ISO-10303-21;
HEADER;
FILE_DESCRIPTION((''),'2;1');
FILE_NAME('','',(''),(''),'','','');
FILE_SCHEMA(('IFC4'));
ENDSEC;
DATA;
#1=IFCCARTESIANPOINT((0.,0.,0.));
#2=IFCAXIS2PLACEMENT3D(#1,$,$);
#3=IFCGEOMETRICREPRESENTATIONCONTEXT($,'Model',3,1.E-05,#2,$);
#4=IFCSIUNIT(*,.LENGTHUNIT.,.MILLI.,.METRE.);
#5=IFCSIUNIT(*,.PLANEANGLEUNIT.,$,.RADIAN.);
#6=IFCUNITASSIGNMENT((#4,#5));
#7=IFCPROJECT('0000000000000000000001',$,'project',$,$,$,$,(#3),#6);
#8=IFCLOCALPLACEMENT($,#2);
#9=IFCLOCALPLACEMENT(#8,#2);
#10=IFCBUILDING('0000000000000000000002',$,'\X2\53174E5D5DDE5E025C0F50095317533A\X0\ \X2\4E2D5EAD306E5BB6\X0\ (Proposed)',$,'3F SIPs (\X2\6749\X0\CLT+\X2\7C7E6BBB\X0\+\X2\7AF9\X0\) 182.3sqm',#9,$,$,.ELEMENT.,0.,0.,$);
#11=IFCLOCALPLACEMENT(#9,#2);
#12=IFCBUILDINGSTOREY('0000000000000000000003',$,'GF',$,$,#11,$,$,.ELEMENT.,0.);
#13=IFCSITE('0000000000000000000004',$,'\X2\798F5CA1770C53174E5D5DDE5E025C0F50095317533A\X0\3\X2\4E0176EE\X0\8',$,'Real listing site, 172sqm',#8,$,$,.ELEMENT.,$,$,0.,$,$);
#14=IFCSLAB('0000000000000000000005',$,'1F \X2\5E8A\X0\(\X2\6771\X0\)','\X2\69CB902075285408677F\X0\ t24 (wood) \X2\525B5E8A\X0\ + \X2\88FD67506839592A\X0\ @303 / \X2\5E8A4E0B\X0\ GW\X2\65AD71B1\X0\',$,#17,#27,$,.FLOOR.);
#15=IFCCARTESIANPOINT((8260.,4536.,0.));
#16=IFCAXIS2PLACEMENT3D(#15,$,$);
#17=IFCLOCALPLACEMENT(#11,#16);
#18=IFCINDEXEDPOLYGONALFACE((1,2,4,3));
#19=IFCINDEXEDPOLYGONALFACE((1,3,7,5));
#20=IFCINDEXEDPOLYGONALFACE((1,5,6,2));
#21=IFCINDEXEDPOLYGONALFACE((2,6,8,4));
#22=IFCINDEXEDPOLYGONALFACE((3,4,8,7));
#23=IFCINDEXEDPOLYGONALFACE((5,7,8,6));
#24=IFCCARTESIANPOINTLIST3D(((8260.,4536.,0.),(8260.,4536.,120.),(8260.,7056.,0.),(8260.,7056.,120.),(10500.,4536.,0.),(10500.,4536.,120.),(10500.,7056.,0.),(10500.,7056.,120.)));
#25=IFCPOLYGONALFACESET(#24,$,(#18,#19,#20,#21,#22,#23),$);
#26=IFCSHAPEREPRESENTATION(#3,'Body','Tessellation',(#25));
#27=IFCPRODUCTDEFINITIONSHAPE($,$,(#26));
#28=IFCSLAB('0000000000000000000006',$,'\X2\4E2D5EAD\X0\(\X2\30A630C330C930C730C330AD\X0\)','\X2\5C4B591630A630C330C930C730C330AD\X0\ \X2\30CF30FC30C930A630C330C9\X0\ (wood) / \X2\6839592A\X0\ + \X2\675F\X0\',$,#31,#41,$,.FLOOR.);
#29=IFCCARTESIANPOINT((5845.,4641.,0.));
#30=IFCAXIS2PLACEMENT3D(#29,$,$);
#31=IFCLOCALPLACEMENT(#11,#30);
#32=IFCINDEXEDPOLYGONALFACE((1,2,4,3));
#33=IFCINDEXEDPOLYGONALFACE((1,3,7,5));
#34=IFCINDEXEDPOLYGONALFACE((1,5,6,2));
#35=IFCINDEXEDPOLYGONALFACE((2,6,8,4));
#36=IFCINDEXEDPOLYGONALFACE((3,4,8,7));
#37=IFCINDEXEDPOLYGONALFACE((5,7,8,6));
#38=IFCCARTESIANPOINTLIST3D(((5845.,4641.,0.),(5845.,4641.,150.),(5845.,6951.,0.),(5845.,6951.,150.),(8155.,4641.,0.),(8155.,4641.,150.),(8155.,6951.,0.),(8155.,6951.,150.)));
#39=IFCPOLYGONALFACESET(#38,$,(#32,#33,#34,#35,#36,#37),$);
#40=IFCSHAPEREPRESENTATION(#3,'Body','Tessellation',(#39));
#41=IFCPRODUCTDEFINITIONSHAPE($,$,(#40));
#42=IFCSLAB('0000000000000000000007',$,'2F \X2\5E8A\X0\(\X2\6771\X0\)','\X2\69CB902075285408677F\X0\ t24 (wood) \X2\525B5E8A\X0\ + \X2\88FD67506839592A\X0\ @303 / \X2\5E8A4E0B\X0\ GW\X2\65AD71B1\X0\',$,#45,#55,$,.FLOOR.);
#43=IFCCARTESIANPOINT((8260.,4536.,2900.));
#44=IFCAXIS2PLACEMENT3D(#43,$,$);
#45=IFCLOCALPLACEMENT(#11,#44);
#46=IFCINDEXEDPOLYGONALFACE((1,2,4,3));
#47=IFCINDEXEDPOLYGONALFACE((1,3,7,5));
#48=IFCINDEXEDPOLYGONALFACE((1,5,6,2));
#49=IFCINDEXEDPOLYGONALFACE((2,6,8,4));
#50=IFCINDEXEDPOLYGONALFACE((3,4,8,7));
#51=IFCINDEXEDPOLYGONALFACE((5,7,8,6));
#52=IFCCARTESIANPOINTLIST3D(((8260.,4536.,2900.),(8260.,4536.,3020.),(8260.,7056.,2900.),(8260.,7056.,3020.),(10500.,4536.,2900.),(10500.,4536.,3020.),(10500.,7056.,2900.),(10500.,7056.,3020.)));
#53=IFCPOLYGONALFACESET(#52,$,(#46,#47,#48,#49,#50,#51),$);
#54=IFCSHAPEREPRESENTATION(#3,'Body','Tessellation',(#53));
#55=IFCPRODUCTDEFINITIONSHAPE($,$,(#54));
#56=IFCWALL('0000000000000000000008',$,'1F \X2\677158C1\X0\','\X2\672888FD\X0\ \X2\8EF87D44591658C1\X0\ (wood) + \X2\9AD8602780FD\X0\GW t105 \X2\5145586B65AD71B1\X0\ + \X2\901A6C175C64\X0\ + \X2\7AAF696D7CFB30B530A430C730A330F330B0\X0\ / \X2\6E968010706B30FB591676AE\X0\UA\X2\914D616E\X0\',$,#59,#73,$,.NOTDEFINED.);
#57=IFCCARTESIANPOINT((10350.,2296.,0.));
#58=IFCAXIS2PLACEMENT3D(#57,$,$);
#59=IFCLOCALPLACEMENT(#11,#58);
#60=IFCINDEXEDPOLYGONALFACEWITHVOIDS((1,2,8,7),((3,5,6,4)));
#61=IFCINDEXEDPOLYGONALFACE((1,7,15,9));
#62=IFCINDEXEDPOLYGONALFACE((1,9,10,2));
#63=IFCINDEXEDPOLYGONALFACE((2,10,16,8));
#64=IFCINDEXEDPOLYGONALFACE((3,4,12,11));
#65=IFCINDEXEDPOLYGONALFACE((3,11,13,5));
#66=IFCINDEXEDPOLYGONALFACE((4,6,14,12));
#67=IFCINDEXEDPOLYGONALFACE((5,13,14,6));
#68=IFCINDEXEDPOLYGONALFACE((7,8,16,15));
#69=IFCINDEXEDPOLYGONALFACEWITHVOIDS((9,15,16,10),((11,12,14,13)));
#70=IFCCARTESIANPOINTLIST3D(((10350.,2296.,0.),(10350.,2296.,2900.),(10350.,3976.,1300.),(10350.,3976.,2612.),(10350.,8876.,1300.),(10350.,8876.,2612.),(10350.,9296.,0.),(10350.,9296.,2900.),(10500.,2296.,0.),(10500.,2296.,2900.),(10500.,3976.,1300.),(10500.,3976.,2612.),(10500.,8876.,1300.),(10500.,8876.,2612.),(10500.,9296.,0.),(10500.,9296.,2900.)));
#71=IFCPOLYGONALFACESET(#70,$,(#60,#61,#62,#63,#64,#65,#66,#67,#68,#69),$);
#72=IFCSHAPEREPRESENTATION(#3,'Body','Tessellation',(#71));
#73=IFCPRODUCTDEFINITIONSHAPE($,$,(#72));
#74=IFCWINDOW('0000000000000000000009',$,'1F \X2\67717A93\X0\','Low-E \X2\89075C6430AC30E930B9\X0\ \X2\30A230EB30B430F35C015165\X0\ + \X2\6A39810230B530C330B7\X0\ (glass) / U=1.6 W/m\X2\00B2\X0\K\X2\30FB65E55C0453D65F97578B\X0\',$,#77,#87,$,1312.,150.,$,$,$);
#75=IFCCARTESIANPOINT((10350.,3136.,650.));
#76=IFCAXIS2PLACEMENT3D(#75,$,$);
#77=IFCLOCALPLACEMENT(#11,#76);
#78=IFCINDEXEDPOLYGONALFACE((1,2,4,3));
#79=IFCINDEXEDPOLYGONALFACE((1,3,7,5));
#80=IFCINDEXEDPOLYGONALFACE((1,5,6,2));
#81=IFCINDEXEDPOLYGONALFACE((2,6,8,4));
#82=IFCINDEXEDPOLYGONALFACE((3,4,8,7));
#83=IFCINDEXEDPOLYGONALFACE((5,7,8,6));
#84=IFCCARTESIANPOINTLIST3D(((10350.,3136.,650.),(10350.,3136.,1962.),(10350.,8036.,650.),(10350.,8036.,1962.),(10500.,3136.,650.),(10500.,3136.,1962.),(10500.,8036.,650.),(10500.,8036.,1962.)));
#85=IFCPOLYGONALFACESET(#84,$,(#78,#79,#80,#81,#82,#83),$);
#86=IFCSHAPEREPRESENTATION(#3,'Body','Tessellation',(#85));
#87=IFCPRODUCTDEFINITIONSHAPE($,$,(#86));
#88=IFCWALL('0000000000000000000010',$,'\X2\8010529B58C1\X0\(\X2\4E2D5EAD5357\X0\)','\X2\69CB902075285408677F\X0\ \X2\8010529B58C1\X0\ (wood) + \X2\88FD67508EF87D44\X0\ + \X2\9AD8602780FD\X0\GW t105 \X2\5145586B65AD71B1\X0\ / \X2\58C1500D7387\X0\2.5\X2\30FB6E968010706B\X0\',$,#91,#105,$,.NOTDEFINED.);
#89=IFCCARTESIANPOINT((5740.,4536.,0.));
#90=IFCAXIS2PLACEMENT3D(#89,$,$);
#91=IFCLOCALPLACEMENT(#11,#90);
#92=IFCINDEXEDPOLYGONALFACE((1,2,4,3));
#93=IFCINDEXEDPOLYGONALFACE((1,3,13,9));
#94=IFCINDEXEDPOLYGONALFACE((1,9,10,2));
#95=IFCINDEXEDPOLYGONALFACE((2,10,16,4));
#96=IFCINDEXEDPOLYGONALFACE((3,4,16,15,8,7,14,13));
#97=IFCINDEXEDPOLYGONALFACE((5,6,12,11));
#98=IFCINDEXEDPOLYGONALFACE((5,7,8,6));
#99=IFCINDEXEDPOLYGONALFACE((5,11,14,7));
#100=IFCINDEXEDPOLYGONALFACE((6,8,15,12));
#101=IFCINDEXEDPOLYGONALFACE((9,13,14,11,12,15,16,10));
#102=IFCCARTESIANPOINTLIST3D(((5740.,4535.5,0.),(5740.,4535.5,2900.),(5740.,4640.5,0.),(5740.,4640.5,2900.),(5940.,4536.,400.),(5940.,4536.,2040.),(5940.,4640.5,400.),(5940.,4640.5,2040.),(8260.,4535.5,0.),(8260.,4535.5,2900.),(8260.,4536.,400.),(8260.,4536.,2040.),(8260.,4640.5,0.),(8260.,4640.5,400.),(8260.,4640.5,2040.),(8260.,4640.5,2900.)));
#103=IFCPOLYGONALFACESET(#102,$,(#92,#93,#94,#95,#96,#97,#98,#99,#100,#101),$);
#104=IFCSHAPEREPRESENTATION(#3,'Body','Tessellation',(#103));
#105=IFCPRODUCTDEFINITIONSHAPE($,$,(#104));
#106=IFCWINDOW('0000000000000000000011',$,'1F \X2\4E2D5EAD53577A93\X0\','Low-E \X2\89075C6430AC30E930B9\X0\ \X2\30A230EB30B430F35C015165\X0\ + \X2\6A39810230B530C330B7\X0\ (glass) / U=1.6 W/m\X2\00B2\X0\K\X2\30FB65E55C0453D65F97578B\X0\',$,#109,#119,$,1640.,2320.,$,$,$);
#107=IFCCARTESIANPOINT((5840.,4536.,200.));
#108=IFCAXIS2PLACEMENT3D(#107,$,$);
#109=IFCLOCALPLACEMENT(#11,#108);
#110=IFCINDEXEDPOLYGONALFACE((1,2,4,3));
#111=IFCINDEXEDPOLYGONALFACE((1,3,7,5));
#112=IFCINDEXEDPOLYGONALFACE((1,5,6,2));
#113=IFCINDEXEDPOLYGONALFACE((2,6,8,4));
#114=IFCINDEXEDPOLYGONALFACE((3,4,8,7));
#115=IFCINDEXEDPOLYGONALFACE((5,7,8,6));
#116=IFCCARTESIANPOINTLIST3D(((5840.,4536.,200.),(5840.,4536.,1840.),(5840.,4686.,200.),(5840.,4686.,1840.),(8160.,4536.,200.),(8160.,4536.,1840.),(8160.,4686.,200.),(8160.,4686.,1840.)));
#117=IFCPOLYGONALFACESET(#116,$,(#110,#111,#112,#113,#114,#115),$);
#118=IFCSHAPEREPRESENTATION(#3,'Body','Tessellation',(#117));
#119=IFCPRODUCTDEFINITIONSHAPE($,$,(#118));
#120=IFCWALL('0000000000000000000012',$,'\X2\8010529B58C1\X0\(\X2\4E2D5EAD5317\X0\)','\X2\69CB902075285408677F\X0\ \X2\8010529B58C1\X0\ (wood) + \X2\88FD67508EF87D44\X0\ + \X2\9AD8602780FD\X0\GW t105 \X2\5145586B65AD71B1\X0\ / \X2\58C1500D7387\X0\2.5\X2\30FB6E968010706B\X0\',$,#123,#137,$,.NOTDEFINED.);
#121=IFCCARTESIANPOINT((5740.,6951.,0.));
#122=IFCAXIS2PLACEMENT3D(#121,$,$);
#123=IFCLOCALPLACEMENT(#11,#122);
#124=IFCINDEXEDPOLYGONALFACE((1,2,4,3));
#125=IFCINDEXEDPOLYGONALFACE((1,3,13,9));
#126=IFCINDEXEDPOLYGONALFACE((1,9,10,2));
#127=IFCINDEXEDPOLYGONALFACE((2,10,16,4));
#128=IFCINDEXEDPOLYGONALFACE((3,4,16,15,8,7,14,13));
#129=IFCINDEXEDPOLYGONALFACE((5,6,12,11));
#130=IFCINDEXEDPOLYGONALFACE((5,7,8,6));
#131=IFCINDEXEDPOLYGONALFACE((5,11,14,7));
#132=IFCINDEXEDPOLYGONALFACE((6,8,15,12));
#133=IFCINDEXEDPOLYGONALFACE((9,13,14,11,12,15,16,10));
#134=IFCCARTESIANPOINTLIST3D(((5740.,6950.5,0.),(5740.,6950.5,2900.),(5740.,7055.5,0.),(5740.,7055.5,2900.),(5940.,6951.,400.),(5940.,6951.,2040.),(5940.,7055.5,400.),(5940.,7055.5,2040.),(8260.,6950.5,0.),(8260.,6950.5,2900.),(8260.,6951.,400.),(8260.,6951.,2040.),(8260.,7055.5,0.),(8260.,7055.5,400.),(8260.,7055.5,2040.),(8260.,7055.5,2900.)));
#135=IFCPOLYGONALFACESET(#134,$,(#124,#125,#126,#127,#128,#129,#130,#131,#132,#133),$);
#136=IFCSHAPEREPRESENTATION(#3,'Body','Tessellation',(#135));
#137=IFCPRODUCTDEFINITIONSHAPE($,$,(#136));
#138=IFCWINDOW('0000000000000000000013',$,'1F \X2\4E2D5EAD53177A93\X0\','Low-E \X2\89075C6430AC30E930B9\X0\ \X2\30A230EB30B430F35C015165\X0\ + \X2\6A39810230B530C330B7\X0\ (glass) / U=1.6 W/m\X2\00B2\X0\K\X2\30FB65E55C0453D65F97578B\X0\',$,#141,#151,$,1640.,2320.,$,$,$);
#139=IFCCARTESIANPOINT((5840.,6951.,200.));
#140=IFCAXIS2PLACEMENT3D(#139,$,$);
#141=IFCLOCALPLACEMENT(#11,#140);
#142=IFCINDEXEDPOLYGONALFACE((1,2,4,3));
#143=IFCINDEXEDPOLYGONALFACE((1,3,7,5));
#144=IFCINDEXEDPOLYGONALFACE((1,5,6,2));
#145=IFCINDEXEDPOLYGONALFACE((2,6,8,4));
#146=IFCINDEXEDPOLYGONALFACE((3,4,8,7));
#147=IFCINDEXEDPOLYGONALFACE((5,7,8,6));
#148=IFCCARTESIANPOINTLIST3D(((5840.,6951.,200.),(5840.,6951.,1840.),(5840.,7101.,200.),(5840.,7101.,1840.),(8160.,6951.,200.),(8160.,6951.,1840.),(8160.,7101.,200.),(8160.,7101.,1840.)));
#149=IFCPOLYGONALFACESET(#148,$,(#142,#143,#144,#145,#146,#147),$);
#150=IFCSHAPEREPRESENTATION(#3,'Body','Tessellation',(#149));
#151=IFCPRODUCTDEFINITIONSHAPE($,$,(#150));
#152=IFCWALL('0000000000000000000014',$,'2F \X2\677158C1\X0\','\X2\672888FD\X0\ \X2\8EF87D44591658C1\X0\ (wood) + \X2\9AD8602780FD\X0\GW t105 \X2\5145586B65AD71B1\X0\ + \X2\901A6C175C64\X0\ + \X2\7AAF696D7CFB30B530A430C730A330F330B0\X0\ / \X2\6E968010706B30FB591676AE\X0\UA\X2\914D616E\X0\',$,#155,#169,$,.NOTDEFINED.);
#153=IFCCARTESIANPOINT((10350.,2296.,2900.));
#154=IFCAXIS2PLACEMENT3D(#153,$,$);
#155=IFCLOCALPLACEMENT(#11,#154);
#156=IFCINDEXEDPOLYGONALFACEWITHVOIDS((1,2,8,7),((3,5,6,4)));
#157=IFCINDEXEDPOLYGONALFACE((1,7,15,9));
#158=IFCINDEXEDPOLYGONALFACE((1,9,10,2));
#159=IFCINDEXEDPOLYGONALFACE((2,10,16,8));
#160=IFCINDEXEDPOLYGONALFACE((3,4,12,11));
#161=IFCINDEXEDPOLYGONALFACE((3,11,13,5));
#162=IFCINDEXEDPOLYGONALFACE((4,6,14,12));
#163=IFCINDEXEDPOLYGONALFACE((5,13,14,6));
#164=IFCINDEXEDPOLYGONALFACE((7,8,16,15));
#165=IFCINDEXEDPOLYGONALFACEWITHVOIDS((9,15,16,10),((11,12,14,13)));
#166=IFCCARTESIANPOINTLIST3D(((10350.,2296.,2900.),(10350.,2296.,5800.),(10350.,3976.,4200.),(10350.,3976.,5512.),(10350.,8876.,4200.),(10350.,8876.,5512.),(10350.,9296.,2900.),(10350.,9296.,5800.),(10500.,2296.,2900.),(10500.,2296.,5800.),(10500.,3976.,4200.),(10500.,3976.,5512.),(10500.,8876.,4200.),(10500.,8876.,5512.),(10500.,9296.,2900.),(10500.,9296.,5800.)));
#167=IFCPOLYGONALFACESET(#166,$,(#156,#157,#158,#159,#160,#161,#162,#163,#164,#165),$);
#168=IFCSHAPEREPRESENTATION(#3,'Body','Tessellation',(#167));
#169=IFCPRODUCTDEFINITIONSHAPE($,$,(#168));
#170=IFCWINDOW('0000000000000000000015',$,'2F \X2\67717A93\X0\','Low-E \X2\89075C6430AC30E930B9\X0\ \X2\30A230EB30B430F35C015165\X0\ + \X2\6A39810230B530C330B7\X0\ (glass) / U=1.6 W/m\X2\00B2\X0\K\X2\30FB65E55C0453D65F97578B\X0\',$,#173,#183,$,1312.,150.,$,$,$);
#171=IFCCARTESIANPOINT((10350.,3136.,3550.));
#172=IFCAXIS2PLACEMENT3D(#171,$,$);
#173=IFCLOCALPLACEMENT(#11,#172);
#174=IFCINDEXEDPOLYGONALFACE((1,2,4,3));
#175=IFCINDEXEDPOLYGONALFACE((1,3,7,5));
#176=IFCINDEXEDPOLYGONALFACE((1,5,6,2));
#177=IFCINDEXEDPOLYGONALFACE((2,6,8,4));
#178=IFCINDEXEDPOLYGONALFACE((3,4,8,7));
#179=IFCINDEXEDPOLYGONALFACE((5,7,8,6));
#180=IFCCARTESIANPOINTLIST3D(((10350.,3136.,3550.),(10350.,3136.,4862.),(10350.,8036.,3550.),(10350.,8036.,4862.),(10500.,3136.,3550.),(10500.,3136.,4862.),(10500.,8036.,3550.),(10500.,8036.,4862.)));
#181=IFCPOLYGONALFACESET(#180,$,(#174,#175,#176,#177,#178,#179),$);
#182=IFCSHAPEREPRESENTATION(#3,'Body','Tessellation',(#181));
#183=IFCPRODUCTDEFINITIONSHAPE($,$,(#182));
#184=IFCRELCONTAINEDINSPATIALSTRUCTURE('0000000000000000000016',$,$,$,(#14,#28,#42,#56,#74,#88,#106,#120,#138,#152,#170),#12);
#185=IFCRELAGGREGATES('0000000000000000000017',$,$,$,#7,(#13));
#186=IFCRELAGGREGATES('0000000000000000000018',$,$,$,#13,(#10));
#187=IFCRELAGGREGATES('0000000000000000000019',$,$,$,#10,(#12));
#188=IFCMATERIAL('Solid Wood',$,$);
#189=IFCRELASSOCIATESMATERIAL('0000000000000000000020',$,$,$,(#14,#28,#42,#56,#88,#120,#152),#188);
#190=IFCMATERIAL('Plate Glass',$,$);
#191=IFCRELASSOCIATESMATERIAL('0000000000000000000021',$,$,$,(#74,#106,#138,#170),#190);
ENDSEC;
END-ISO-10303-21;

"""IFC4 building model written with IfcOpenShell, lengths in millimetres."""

from ifc_helpers import new_model, si_unit, frame, frame_2d, origin, place, context, project, spatial, rectangle, extrude, material, element, fill, save


model = new_model("IFC4")

# Units and contexts
model_context = context("Model", 3, precision=1e-05, world=origin())
ifc_project = project(units=[si_unit("LENGTHUNIT", "METRE", prefix="MILLI"), si_unit("PLANEANGLEUNIT", "RADIAN")], contexts=[model_context])

# Site, building, storey
site_placement = place(None, origin())
site = spatial("IfcSite", under=ifc_project, at=site_placement, Name="福岡県北九州市小倉北区3丁目8", ObjectType="Real listing site, 172sqm", CompositionType="ELEMENT", RefElevation=0.0)
building_placement = place(site_placement, origin())
building = spatial("IfcBuilding", under=site, at=building_placement, Name="北九州市小倉北区 中庭の家 (Proposed)", ObjectType="3F SIPs (杉CLT+籾殻+竹) 182.3sqm", CompositionType="ELEMENT", ElevationOfRefHeight=0.0, ElevationOfTerrain=0.0)
storey_placement = place(building_placement, origin())
storey = spatial("IfcBuildingStorey", under=building, at=storey_placement, Name="GF", CompositionType="ELEMENT", Elevation=0.0)

# Slabs
ifc_material_1 = material(Name="Solid Wood")
slab_1_placement = place(storey_placement, frame((8260.0, 4536.0, 0.0)))
element("IfcSlab", 1, at=slab_1_placement, inside=storey, material=ifc_material_1, Name="1F 床(東)", Description="構造用合板 t24 (wood) 剛床 + 製材根太 @303 / 床下 GW断熱", PredefinedType="FLOOR", context=model_context, shape_type="SweptSolid", body=[
    extrude(rectangle(XDim=2240.0, YDim=2520.0, at=frame_2d((1120.0, 1260.0))), frame((8260.0, 4536.0, 0.0)), (0.0, 0.0, 1.0), 120.0),
])
slab_2_placement = place(storey_placement, frame((5845.0, 4641.0, 0.0)))
element("IfcSlab", 2, at=slab_2_placement, inside=storey, material=ifc_material_1, Name="中庭(ウッドデッキ)", Description="屋外ウッドデッキ ハードウッド (wood) / 根太 + 束", PredefinedType="FLOOR", context=model_context, shape_type="SweptSolid", body=[
    extrude(rectangle(XDim=2310.0, YDim=2310.0, at=frame_2d((1155.0, 1155.0))), frame((5845.0, 4641.0, 0.0)), (0.0, 0.0, 1.0), 150.0),
])
slab_3_placement = place(storey_placement, frame((8260.0, 4536.0, 2900.0)))
element("IfcSlab", 3, at=slab_3_placement, inside=storey, material=ifc_material_1, Name="2F 床(東)", Description="構造用合板 t24 (wood) 剛床 + 製材根太 @303 / 床下 GW断熱", PredefinedType="FLOOR", context=model_context, shape_type="SweptSolid", body=[
    extrude(rectangle(XDim=2240.0, YDim=2520.0, at=frame_2d((1120.0, 1260.0))), frame((8260.0, 4536.0, 2900.0)), (0.0, 0.0, 1.0), 120.0),
])

# Walls, openings, windows
wall_1_placement = place(storey_placement, frame((10350.0, 2296.0, 0.0)))
wall_1 = element("IfcWall", 4, at=wall_1_placement, inside=storey, material=ifc_material_1, Name="1F 東壁", Description="木製 軸組外壁 (wood) + 高性能GW t105 充填断熱 + 通気層 + 窯業系サイディング / 準耐火・外皮UA配慮", PredefinedType="NOTDEFINED", context=model_context, shape_type="SweptSolid", body=[
    extrude(rectangle(XDim=150.0, YDim=7000.0, at=frame_2d((75.0, 3500.0))), frame((10350.0, 2296.0, 0.0)), (0.0, 0.0, 1.0), 2900.0),
])
opening_1_placement = place(storey_placement, frame((10350.0, 3136.0, 650.0)))
opening_1 = element("IfcOpeningElement", 5, at=opening_1_placement, cuts=wall_1, PredefinedType="NOTDEFINED", context=model_context, shape_type="SweptSolid", body=[
    extrude(rectangle(XDim=150.0, YDim=4900.0, at=frame_2d((75.0, 2450.0))), frame((10350.0, 3136.0, 650.0)), (0.0, 0.0, 1.0), 1312.0),
])
ifc_material_2 = material(Name="Plate Glass")
window_1_placement = place(storey_placement, frame((10350.0, 3136.0, 650.0)))
window_1 = element("IfcWindow", 6, at=window_1_placement, inside=storey, material=ifc_material_2, Name="1F 東窓", Description="Low-E 複層ガラス アルゴン封入 + 樹脂サッシ (glass) / U=1.6 W/m²K・日射取得型", OverallHeight=1312.0, OverallWidth=150.0, context=model_context, shape_type="SweptSolid", body=[
    extrude(rectangle(XDim=150.0, YDim=4900.0, at=frame_2d((75.0, 2450.0))), frame((10350.0, 3136.0, 650.0)), (0.0, 0.0, 1.0), 1312.0),
])
fill(opening_1, window_1)
wall_2_placement = place(storey_placement, frame((5740.0, 4536.0, 0.0)))
wall_2 = element("IfcWall", 7, at=wall_2_placement, inside=storey, material=ifc_material_1, Name="耐力壁(中庭南)", Description="構造用合板 耐力壁 (wood) + 製材軸組 + 高性能GW t105 充填断熱 / 壁倍率2.5・準耐火", PredefinedType="NOTDEFINED", context=model_context, shape_type="SweptSolid", body=[
    extrude(rectangle(XDim=2520.0, YDim=105.0, at=frame_2d((1260.0, 52.0))), frame((5740.0, 4536.0, 0.0)), (0.0, 0.0, 1.0), 2900.0),
])
opening_2_placement = place(storey_placement, frame((5840.0, 4536.0, 200.0)))
opening_2 = element("IfcOpeningElement", 8, at=opening_2_placement, cuts=wall_2, PredefinedType="NOTDEFINED", context=model_context, shape_type="SweptSolid", body=[
    extrude(rectangle(XDim=2320.0, YDim=150.0, at=frame_2d((1160.0, 75.0))), frame((5840.0, 4536.0, 200.0)), (0.0, 0.0, 1.0), 1640.0),
])
window_2_placement = place(storey_placement, frame((5840.0, 4536.0, 200.0)))
window_2 = element("IfcWindow", 9, at=window_2_placement, inside=storey, material=ifc_material_2, Name="1F 中庭南窓", Description="Low-E 複層ガラス アルゴン封入 + 樹脂サッシ (glass) / U=1.6 W/m²K・日射取得型", OverallHeight=1640.0, OverallWidth=2320.0, context=model_context, shape_type="SweptSolid", body=[
    extrude(rectangle(XDim=2320.0, YDim=150.0, at=frame_2d((1160.0, 75.0))), frame((5840.0, 4536.0, 200.0)), (0.0, 0.0, 1.0), 1640.0),
])
fill(opening_2, window_2)
wall_3_placement = place(storey_placement, frame((5740.0, 6951.0, 0.0)))
wall_3 = element("IfcWall", 10, at=wall_3_placement, inside=storey, material=ifc_material_1, Name="耐力壁(中庭北)", Description="構造用合板 耐力壁 (wood) + 製材軸組 + 高性能GW t105 充填断熱 / 壁倍率2.5・準耐火", PredefinedType="NOTDEFINED", context=model_context, shape_type="SweptSolid", body=[
    extrude(rectangle(XDim=2520.0, YDim=105.0, at=frame_2d((1260.0, 52.0))), frame((5740.0, 6951.0, 0.0)), (0.0, 0.0, 1.0), 2900.0),
])
opening_3_placement = place(storey_placement, frame((5840.0, 6951.0, 200.0)))
opening_3 = element("IfcOpeningElement", 11, at=opening_3_placement, cuts=wall_3, PredefinedType="NOTDEFINED", context=model_context, shape_type="SweptSolid", body=[
    extrude(rectangle(XDim=2320.0, YDim=150.0, at=frame_2d((1160.0, 75.0))), frame((5840.0, 6951.0, 200.0)), (0.0, 0.0, 1.0), 1640.0),
])
window_3_placement = place(storey_placement, frame((5840.0, 6951.0, 200.0)))
window_3 = element("IfcWindow", 12, at=window_3_placement, inside=storey, material=ifc_material_2, Name="1F 中庭北窓", Description="Low-E 複層ガラス アルゴン封入 + 樹脂サッシ (glass) / U=1.6 W/m²K・日射取得型", OverallHeight=1640.0, OverallWidth=2320.0, context=model_context, shape_type="SweptSolid", body=[
    extrude(rectangle(XDim=2320.0, YDim=150.0, at=frame_2d((1160.0, 75.0))), frame((5840.0, 6951.0, 200.0)), (0.0, 0.0, 1.0), 1640.0),
])
fill(opening_3, window_3)

# Wall, opening, window
wall_4_placement = place(storey_placement, frame((10350.0, 2296.0, 2900.0)))
wall_4 = element("IfcWall", 13, at=wall_4_placement, inside=storey, material=ifc_material_1, Name="2F 東壁", Description="木製 軸組外壁 (wood) + 高性能GW t105 充填断熱 + 通気層 + 窯業系サイディング / 準耐火・外皮UA配慮", PredefinedType="NOTDEFINED", context=model_context, shape_type="SweptSolid", body=[
    extrude(rectangle(XDim=150.0, YDim=7000.0, at=frame_2d((75.0, 3500.0))), frame((10350.0, 2296.0, 2900.0)), (0.0, 0.0, 1.0), 2900.0),
])
opening_4_placement = place(storey_placement, frame((10350.0, 3136.0, 3550.0)))
opening_4 = element("IfcOpeningElement", 14, at=opening_4_placement, cuts=wall_4, PredefinedType="NOTDEFINED", context=model_context, shape_type="SweptSolid", body=[
    extrude(rectangle(XDim=150.0, YDim=4900.0, at=frame_2d((75.0, 2450.0))), frame((10350.0, 3136.0, 3550.0)), (0.0, 0.0, 1.0), 1312.0),
])
window_4_placement = place(storey_placement, frame((10350.0, 3136.0, 3550.0)))
window_4 = element("IfcWindow", 15, at=window_4_placement, inside=storey, material=ifc_material_2, Name="2F 東窓", Description="Low-E 複層ガラス アルゴン封入 + 樹脂サッシ (glass) / U=1.6 W/m²K・日射取得型", OverallHeight=1312.0, OverallWidth=150.0, context=model_context, shape_type="SweptSolid", body=[
    extrude(rectangle(XDim=150.0, YDim=4900.0, at=frame_2d((75.0, 2450.0))), frame((10350.0, 3136.0, 3550.0)), (0.0, 0.0, 1.0), 1312.0),
])
fill(opening_4, window_4)

save(model, "model.ifc")
